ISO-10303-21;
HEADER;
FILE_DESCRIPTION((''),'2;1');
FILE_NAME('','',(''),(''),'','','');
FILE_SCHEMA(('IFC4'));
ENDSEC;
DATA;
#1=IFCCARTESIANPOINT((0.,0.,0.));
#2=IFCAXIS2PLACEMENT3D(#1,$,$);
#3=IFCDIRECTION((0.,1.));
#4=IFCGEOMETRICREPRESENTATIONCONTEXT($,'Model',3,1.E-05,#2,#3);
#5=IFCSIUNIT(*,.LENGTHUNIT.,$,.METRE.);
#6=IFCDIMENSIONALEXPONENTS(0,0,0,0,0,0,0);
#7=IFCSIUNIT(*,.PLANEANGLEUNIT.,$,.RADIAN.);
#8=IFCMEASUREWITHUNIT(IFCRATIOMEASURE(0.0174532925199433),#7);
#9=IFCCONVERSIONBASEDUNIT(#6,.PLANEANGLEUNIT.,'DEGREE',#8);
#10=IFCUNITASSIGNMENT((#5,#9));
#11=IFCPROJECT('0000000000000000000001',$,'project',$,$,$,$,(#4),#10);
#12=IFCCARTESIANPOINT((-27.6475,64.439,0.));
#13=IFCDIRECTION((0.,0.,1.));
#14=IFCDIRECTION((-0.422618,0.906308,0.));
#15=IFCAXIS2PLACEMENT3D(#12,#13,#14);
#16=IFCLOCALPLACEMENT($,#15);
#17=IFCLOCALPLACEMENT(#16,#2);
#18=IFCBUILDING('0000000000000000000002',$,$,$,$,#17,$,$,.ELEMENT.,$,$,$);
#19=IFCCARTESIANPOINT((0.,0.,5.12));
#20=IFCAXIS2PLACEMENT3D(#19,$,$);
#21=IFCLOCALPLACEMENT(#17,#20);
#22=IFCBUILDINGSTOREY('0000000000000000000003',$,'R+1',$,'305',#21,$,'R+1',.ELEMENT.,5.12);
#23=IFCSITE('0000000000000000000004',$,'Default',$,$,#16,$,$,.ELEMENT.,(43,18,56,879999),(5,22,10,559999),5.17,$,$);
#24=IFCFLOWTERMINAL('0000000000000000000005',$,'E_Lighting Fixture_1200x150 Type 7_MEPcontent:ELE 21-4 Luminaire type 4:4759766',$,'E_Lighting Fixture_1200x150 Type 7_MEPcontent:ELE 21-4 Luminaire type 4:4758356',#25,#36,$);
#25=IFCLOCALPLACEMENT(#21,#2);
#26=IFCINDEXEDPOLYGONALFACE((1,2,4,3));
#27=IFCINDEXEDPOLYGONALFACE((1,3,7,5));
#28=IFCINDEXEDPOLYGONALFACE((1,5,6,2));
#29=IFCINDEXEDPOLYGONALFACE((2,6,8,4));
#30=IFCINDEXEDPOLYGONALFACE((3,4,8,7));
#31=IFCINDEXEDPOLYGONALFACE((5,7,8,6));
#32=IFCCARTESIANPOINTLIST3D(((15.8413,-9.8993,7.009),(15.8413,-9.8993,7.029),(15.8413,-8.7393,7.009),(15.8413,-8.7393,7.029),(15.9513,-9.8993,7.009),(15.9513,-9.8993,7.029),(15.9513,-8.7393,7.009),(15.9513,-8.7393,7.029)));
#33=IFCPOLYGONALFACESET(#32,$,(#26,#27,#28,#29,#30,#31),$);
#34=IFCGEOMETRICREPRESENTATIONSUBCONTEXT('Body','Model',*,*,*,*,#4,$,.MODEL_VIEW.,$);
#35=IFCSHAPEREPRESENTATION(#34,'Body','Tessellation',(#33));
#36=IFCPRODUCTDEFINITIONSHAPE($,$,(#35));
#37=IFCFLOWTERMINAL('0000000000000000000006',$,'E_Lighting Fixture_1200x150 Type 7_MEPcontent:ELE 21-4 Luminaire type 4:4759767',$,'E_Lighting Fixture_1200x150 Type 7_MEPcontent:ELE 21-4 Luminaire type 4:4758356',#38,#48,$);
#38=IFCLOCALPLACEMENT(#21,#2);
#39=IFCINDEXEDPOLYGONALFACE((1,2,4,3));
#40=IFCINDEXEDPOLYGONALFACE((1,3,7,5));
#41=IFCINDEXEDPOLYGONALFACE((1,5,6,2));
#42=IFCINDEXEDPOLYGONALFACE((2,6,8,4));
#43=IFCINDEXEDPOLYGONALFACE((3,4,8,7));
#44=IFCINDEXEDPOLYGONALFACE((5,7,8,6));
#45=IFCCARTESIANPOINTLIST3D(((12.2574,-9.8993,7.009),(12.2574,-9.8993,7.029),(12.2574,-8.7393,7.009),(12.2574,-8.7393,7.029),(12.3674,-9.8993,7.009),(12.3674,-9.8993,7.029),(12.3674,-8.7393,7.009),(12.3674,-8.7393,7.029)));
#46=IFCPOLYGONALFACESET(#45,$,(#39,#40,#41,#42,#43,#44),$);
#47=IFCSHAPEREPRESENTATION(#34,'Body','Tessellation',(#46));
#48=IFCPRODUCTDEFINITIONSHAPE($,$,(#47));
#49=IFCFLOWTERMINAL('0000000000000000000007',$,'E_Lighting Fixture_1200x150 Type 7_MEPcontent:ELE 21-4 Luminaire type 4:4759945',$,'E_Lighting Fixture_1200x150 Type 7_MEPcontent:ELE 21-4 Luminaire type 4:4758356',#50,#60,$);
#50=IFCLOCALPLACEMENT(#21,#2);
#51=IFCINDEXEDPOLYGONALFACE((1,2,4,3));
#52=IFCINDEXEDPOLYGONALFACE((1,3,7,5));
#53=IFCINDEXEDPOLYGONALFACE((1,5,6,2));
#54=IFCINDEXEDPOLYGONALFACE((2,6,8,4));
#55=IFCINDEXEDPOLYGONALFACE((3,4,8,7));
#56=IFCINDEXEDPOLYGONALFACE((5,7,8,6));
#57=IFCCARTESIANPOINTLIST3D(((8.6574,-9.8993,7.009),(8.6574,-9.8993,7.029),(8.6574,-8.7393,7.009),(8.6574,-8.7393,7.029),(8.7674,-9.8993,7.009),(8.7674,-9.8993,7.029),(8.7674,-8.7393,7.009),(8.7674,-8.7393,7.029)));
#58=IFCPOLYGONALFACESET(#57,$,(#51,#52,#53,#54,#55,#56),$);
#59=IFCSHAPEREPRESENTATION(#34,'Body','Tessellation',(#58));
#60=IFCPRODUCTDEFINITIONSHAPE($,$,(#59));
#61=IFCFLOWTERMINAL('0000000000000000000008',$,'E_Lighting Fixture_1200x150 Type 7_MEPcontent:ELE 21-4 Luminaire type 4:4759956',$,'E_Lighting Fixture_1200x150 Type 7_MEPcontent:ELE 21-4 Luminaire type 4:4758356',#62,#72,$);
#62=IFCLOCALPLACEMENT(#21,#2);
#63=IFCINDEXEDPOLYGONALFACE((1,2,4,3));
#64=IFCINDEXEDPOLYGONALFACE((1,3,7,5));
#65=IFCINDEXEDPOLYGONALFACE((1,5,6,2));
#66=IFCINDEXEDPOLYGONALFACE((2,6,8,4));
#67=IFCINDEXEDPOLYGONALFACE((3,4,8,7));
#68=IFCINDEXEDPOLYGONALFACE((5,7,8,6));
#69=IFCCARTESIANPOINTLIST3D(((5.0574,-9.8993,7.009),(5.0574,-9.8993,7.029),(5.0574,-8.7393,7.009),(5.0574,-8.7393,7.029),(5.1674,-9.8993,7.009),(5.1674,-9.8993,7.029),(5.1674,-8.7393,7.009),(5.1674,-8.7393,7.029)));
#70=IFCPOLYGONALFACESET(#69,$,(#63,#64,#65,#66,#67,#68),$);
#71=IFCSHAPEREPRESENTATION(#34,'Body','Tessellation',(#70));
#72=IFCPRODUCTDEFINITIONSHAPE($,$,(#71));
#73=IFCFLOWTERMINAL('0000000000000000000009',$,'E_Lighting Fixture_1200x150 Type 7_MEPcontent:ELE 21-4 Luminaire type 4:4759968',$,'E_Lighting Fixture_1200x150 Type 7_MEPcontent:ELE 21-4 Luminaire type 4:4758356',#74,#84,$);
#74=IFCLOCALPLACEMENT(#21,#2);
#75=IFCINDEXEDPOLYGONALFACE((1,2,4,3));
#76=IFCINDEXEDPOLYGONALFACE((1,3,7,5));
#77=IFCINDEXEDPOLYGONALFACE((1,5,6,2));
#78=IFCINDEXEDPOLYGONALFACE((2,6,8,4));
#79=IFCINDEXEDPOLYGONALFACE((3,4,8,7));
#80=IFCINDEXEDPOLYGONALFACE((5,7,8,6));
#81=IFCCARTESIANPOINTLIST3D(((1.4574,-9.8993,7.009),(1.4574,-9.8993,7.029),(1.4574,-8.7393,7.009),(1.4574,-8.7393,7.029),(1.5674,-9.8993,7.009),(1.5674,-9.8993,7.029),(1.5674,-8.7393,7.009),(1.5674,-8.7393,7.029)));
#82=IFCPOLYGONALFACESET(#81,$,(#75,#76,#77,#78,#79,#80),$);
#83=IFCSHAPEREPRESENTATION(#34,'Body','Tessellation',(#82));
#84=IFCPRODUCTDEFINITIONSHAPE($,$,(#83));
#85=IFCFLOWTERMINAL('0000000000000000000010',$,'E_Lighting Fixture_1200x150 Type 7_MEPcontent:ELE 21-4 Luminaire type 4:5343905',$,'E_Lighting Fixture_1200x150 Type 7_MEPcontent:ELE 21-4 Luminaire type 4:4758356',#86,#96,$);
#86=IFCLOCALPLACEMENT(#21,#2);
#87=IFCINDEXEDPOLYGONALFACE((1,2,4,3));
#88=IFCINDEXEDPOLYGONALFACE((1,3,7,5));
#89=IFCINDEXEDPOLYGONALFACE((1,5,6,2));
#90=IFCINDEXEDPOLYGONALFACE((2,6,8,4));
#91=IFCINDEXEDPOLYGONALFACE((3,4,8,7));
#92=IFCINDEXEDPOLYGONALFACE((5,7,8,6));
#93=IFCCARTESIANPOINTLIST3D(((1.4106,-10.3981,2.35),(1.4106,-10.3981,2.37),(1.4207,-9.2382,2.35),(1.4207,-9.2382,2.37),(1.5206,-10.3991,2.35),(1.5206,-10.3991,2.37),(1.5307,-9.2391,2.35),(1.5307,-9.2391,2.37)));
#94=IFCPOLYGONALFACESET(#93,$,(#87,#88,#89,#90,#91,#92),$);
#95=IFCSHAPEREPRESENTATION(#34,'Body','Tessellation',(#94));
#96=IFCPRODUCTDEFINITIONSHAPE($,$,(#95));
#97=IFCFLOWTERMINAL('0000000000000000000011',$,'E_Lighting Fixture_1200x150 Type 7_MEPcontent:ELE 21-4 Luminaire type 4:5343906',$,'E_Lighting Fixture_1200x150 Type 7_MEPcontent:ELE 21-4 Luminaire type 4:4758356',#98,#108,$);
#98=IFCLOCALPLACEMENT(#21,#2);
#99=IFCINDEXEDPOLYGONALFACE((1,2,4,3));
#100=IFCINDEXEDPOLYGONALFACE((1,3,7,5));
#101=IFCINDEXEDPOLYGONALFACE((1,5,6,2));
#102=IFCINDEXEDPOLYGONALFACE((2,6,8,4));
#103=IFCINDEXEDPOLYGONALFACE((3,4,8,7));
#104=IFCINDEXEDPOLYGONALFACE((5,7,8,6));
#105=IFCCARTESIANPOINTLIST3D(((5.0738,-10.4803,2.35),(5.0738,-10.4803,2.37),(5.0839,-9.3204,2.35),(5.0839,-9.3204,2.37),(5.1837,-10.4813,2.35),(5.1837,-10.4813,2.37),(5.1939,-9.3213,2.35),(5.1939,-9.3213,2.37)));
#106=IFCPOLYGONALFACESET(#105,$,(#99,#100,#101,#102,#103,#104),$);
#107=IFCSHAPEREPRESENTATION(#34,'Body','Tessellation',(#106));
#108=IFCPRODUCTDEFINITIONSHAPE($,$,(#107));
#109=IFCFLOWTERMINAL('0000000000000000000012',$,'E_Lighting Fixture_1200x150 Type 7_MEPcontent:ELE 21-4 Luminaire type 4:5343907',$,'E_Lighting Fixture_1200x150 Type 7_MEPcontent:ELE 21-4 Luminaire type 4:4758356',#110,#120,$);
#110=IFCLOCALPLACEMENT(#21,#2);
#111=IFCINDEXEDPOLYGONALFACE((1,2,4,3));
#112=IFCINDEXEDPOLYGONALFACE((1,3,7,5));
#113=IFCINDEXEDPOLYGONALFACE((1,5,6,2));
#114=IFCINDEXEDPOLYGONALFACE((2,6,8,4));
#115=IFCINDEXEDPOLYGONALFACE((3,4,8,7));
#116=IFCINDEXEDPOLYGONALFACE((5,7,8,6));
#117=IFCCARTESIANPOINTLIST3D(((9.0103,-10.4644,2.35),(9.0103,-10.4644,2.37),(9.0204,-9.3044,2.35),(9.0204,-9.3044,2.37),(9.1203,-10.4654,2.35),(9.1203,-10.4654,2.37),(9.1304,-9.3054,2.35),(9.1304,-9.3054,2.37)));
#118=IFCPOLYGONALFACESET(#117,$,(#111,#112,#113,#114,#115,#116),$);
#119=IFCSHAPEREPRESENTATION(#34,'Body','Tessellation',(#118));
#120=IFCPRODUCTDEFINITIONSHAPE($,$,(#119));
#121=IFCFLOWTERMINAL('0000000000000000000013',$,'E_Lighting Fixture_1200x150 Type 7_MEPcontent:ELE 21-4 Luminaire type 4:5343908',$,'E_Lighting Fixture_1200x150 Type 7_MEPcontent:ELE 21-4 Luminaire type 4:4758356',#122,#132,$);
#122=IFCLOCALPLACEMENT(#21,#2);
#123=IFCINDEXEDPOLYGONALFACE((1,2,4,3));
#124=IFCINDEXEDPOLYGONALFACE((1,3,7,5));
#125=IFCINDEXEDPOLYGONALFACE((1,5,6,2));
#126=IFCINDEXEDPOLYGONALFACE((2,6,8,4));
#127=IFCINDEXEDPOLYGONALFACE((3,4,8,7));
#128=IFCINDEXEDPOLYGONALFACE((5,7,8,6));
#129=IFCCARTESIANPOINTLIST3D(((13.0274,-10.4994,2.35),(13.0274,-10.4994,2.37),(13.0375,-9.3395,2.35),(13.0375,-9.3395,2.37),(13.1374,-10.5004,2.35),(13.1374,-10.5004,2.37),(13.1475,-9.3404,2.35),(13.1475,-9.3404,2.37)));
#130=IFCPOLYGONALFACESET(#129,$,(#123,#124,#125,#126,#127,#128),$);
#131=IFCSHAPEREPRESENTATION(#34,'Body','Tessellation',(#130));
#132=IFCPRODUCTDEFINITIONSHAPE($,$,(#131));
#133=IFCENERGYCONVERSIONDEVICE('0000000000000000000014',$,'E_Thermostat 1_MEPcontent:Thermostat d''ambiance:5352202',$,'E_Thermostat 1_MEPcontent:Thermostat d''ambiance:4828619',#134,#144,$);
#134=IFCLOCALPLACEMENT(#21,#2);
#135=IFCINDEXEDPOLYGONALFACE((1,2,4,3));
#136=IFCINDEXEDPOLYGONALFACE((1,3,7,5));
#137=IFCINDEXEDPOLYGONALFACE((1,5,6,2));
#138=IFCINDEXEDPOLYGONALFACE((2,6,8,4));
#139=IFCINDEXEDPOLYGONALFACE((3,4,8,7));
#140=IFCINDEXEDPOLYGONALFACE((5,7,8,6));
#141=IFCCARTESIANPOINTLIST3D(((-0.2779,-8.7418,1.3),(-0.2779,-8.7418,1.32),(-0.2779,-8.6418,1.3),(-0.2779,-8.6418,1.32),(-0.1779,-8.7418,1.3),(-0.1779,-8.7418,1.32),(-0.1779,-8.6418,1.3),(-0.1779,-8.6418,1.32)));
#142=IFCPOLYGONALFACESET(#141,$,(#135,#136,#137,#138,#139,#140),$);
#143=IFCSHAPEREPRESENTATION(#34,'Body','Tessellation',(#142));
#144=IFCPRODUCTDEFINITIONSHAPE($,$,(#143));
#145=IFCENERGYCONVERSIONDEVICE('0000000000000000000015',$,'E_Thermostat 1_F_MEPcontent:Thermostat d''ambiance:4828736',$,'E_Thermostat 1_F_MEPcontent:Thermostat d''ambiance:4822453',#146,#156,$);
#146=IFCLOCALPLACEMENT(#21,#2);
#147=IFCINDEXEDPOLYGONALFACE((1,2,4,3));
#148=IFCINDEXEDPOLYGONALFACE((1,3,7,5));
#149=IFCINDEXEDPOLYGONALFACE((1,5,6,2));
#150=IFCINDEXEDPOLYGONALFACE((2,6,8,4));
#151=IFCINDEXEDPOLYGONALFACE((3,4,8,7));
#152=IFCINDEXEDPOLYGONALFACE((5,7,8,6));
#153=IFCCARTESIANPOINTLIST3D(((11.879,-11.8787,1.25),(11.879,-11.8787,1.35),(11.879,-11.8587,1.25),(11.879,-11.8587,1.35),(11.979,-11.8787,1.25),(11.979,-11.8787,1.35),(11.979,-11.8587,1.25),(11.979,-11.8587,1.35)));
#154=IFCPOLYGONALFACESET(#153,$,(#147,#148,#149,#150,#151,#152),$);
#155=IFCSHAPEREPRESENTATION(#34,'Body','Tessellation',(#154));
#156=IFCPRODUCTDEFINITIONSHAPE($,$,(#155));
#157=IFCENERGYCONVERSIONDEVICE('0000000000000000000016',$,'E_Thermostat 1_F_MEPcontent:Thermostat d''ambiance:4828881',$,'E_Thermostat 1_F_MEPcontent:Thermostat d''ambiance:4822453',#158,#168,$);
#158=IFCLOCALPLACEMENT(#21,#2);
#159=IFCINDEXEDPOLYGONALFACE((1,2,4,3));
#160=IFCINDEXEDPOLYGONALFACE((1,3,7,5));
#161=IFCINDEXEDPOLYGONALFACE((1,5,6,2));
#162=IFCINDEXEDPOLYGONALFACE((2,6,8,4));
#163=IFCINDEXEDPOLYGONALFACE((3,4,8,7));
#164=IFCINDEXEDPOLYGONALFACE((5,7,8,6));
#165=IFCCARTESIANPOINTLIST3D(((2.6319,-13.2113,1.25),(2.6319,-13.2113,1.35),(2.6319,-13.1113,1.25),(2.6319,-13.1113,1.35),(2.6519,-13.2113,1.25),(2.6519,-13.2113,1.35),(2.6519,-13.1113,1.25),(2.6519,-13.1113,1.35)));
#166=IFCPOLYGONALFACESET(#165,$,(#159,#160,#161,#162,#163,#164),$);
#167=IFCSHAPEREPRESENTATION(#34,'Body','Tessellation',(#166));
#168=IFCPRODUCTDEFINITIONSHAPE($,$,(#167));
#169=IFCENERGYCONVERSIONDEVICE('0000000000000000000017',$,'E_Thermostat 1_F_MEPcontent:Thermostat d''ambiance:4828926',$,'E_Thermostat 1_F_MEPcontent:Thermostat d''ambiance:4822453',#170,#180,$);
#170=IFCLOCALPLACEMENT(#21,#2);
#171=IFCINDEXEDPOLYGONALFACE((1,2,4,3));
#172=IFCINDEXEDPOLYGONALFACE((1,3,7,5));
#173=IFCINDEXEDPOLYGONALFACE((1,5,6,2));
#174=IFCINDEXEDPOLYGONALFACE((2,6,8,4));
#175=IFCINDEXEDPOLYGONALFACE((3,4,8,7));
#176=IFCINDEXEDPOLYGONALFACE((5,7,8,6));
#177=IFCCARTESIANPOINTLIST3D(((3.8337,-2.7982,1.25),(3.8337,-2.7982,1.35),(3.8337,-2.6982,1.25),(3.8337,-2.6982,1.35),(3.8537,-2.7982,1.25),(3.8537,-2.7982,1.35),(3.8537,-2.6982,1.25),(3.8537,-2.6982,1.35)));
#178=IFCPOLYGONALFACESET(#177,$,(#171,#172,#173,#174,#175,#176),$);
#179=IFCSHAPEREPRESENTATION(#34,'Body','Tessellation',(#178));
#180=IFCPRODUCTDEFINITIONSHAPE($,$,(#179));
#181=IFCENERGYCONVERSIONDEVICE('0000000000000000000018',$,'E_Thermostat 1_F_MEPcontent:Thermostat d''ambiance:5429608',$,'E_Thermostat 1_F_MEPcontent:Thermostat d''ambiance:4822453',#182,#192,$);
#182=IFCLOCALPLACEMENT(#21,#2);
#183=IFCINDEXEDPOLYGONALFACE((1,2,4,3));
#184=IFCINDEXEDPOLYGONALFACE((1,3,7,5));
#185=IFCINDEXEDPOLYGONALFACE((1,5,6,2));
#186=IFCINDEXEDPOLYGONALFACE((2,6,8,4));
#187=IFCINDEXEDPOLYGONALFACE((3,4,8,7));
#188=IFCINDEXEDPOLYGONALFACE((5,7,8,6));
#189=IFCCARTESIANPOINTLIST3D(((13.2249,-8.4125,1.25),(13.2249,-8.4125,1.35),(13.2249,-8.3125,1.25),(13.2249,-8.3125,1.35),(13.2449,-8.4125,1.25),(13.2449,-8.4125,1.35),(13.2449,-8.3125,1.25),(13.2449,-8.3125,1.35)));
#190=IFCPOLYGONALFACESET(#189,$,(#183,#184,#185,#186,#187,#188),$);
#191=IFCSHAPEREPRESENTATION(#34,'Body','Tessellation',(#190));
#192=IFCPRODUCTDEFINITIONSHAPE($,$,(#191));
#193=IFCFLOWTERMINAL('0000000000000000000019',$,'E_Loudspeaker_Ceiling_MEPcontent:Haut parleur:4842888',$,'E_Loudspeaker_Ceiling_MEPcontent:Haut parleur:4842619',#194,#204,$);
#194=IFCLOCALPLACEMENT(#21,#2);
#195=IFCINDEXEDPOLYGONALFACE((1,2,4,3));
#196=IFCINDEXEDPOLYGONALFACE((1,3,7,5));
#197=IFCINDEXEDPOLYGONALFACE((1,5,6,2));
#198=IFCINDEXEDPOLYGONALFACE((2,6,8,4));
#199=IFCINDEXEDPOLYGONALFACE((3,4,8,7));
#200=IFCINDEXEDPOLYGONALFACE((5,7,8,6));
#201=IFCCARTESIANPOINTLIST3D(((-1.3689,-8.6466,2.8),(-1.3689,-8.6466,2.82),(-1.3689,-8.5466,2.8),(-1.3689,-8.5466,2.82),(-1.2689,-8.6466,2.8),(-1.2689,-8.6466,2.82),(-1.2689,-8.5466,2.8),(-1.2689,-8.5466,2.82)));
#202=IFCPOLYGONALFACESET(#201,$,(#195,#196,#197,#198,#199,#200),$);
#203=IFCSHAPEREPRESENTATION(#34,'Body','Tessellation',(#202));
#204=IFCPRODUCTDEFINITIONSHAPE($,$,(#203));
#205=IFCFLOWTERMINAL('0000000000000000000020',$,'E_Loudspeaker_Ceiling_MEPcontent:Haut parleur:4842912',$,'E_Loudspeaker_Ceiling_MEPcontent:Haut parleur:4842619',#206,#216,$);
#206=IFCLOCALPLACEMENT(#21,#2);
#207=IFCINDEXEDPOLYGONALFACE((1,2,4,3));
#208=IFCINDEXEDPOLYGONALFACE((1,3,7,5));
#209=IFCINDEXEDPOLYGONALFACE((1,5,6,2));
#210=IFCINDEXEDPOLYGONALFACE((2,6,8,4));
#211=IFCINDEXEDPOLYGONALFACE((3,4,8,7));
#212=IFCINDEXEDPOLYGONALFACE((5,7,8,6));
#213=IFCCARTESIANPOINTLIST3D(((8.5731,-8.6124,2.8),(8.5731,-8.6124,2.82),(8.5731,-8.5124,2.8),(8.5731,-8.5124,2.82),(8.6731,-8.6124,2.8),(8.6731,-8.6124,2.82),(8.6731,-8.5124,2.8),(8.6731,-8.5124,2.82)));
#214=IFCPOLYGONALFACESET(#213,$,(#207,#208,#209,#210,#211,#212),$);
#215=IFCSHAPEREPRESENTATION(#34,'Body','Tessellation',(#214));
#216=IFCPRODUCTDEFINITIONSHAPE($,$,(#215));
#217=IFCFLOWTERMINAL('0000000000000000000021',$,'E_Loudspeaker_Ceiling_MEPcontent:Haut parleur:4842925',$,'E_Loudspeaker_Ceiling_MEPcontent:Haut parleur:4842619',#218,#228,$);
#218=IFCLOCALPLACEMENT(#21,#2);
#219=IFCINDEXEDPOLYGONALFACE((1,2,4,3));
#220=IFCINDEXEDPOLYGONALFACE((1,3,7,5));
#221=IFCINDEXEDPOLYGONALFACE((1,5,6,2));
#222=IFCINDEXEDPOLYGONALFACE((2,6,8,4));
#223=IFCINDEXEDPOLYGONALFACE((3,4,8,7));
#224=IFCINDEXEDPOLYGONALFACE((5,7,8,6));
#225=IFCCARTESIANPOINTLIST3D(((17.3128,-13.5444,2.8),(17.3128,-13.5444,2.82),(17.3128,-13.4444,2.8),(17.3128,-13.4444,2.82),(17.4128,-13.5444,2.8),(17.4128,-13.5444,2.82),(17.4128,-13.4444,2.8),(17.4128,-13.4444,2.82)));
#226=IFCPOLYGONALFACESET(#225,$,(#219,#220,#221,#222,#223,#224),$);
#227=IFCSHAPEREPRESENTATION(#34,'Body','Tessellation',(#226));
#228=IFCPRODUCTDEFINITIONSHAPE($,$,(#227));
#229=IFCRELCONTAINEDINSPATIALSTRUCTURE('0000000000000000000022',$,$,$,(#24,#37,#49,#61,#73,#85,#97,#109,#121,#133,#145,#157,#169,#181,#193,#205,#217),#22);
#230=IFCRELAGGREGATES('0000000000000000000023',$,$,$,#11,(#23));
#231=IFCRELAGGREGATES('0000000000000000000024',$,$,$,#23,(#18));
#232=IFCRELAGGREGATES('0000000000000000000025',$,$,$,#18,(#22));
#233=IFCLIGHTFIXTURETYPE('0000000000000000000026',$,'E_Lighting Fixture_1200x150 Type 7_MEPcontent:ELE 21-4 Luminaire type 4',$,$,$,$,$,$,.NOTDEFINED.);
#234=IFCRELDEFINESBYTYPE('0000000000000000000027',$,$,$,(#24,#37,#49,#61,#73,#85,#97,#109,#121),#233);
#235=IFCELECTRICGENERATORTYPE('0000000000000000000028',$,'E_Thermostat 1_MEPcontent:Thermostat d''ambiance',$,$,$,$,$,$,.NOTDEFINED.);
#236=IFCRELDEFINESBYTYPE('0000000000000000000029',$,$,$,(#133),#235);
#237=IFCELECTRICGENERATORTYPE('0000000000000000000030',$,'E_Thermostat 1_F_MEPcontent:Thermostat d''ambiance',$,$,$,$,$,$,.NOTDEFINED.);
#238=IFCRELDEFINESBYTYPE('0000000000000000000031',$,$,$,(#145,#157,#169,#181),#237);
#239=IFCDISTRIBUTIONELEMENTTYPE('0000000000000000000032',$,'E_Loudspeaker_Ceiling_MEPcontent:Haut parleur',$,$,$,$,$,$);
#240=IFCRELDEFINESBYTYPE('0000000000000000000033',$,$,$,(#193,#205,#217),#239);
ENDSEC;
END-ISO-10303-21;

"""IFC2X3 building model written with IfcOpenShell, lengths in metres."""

from ifc_helpers import new_model, entity, si_unit, converted_unit, direction, frame, origin, origin_2d_with_axis, place, context, subcontext, project, spatial, rectangle, extrude, source, transform, mapped, type_object, type_shapes, element, save


model = new_model("IFC2X3")

# Units and contexts
model_context = context("Model", 3, precision=1e-05, world=origin(), true_north=direction((0.0, 1.0)))
body_context = subcontext(model_context, "Body", "Model", "MODEL_VIEW")
ifc_project = project(units=[si_unit("LENGTHUNIT", "METRE"), converted_unit("PLANEANGLEUNIT", "DEGREE", entity("IfcRatioMeasure", 0.0174532925199433), si_unit("PLANEANGLEUNIT", "RADIAN"), dimensions=[0, 0, 0, 0, 0, 0, 0])], contexts=[model_context])

# Site, building, storey
site_placement = place(None, frame((-27.6475, 64.439, 0.0), z_axis=(0.0, 0.0, 1.0), x_axis=(-0.422618, 0.906308, 0.0)))
site = spatial("IfcSite", under=ifc_project, at=site_placement, Name="Default", CompositionType="ELEMENT", RefLatitude=(43, 18, 56, 879999), RefLongitude=(5, 22, 10, 559999), RefElevation=5.17)
building_placement = place(site_placement, origin())
building = spatial("IfcBuilding", under=site, at=building_placement, CompositionType="ELEMENT")
storey_placement = place(building_placement, frame((0.0, 0.0, 5.12)))
storey = spatial("IfcBuildingStorey", under=building, at=storey_placement, Name="R+1", ObjectType="305", LongName="R+1", CompositionType="ELEMENT", Elevation=5.12)

# Flow terminals
light_fixture_type_1 = type_object("IfcLightFixtureType", Name="E_Lighting Fixture_1200x150 Type 7_MEPcontent:ELE 21-4 Luminaire type 4", PredefinedType="NOTDEFINED")
shared_shape_1 = source(origin(), body_context, "Body", "SweptSolid", [
    extrude(rectangle(XDim=0.11, YDim=1.16, at=origin_2d_with_axis()), frame((0.0, 0.0, 0.0), z_axis=(0.0, 0.0, 1.0), x_axis=(0.0, -1.0, 0.0)), (0.0, 0.0, 1.0), 0.02),
])
type_shapes(light_fixture_type_1, [shared_shape_1])
for number, where, z_axis, x_axis, name in (
    (1, (15.8963, -9.3193, 7.009), (0.0, 0.0, 1.0), (0.0, -1.0, 0.0), "E_Lighting Fixture_1200x150 Type 7_MEPcontent:ELE 21-4 Luminaire type 4:4759766"),
    (2, (12.3124, -9.3193, 7.009), (0.0, 0.0, 1.0), (0.0, -1.0, 0.0), "E_Lighting Fixture_1200x150 Type 7_MEPcontent:ELE 21-4 Luminaire type 4:4759767"),
    (3, (8.7124, -9.3193, 7.009), (0.0, 0.0, 1.0), (0.0, -1.0, 0.0), "E_Lighting Fixture_1200x150 Type 7_MEPcontent:ELE 21-4 Luminaire type 4:4759945"),
    (4, (5.1124, -9.3193, 7.009), (0.0, 0.0, 1.0), (0.0, -1.0, 0.0), "E_Lighting Fixture_1200x150 Type 7_MEPcontent:ELE 21-4 Luminaire type 4:4759956"),
    (5, (1.5124, -9.3193, 7.009), (0.0, 0.0, 1.0), (0.0, -1.0, 0.0), "E_Lighting Fixture_1200x150 Type 7_MEPcontent:ELE 21-4 Luminaire type 4:4759968"),
    (6, (1.4706, -9.8186, 2.35), (0.0, 0.0, 1.0), (-0.008718, -0.999962, 0.0), "E_Lighting Fixture_1200x150 Type 7_MEPcontent:ELE 21-4 Luminaire type 4:5343905"),
    (7, (5.1338, -9.9008, 2.35), (0.0, 0.0, 1.0), (-0.008718, -0.999962, 0.0), "E_Lighting Fixture_1200x150 Type 7_MEPcontent:ELE 21-4 Luminaire type 4:5343906"),
    (8, (9.0703, -9.8849, 2.35), (0.0, 0.0, 1.0), (-0.008718, -0.999962, 0.0), "E_Lighting Fixture_1200x150 Type 7_MEPcontent:ELE 21-4 Luminaire type 4:5343907"),
    (9, (13.0875, -9.9199, 2.35), (0.0, 0.0, 1.0), (-0.008718, -0.999962, 0.0), "E_Lighting Fixture_1200x150 Type 7_MEPcontent:ELE 21-4 Luminaire type 4:5343908"),
):
    element("IfcFlowTerminal", number, at=place(storey_placement, frame(where, z_axis=z_axis, x_axis=x_axis)), inside=storey, type_object=light_fixture_type_1, Name=name, ObjectType="E_Lighting Fixture_1200x150 Type 7_MEPcontent:ELE 21-4 Luminaire type 4:4758356", context=body_context, shape_type="MappedRepresentation", body=[
        mapped(shared_shape_1, transform((0.0, 0.0, 0.0), scale=1.0)),
    ])

# Energy conversion devices
electric_generator_type_1 = type_object("IfcElectricGeneratorType", Name="E_Thermostat 1_MEPcontent:Thermostat d'ambiance", PredefinedType="NOTDEFINED")
shared_shape_2 = source(origin(), body_context, "Body", "SweptSolid", [
    extrude(rectangle(XDim=0.1, YDim=0.1, at=origin_2d_with_axis()), frame((0.0, 0.0, 0.0), z_axis=(0.0, 0.0, 1.0), x_axis=(0.0, -1.0, 0.0)), (0.0, 0.0, 1.0), 0.02),
])
type_shapes(electric_generator_type_1, [shared_shape_2])
energy_conversion_device_placement = place(storey_placement, frame((-0.2279, -8.6918, 1.3)))
element("IfcEnergyConversionDevice", 10, at=energy_conversion_device_placement, inside=storey, type_object=electric_generator_type_1, Name="E_Thermostat 1_MEPcontent:Thermostat d'ambiance:5352202", ObjectType="E_Thermostat 1_MEPcontent:Thermostat d'ambiance:4828619", context=body_context, shape_type="MappedRepresentation", body=[
    mapped(shared_shape_2, transform((0.0, 0.0, 0.0), scale=1.0)),
])
electric_generator_type_2 = type_object("IfcElectricGeneratorType", Name="E_Thermostat 1_F_MEPcontent:Thermostat d'ambiance", PredefinedType="NOTDEFINED")
shared_shape_3 = source(origin(), body_context, "Body", "SweptSolid", [
    extrude(rectangle(XDim=0.1, YDim=0.1, at=origin_2d_with_axis()), frame((0.0, 0.0, 0.0), z_axis=(0.0, 0.0, 1.0), x_axis=(0.0, 1.0, 0.0)), (0.0, 0.0, 1.0), 0.02),
])
type_shapes(electric_generator_type_2, [shared_shape_3])
for number, where, z_axis, x_axis, name in (
    (11, (11.929, -11.8587, 1.3), (0.0, -1.0, 0.0), (-1.0, 0.0, 0.0), "E_Thermostat 1_F_MEPcontent:Thermostat d'ambiance:4828736"),
    (12, (2.6519, -13.1613, 1.3), (-1.0, 0.0, 0.0), (0.0, -1.0, 0.0), "E_Thermostat 1_F_MEPcontent:Thermostat d'ambiance:4828881"),
    (13, (3.8537, -2.7482, 1.3), (-1.0, 0.0, 0.0), (0.0, -1.0, 0.0), "E_Thermostat 1_F_MEPcontent:Thermostat d'ambiance:4828926"),
    (14, (13.2449, -8.3625, 1.3), (-1.0, 0.0, 0.0), (0.0, 1.0, 0.0), "E_Thermostat 1_F_MEPcontent:Thermostat d'ambiance:5429608"),
):
    element("IfcEnergyConversionDevice", number, at=place(storey_placement, frame(where, z_axis=z_axis, x_axis=x_axis)), inside=storey, type_object=electric_generator_type_2, Name=name, ObjectType="E_Thermostat 1_F_MEPcontent:Thermostat d'ambiance:4822453", context=body_context, shape_type="MappedRepresentation", body=[
        mapped(shared_shape_3, transform((0.0, 0.0, 0.0), scale=1.0)),
    ])

# Flow terminals
distribution_element_type_1 = type_object("IfcDistributionElementType", Name="E_Loudspeaker_Ceiling_MEPcontent:Haut parleur")
shared_shape_4 = source(origin(), body_context, "Body", "SweptSolid", [
    extrude(rectangle(XDim=0.1, YDim=0.1, at=origin_2d_with_axis()), frame((0.0, 0.0, 0.0), z_axis=(0.0, 0.0, 1.0), x_axis=(0.0, -1.0, 0.0)), (0.0, 0.0, 1.0), 0.02),
])
type_shapes(distribution_element_type_1, [shared_shape_4])
for number, where, name in (
    (15, (-1.3189, -8.5966, 2.8), "E_Loudspeaker_Ceiling_MEPcontent:Haut parleur:4842888"),
    (16, (8.6231, -8.5624, 2.8), "E_Loudspeaker_Ceiling_MEPcontent:Haut parleur:4842912"),
):
    element("IfcFlowTerminal", number, at=place(storey_placement, frame(where)), inside=storey, type_object=distribution_element_type_1, Name=name, ObjectType="E_Loudspeaker_Ceiling_MEPcontent:Haut parleur:4842619", context=body_context, shape_type="MappedRepresentation", body=[
        mapped(shared_shape_4, transform((0.0, 0.0, 0.0), scale=1.0)),
    ])
for number, where, z_axis, x_axis, name in (
    (17, (17.3628, -13.4944, 2.8), (0.0, 0.0, 1.0), (0.0, 1.0, 0.0), "E_Loudspeaker_Ceiling_MEPcontent:Haut parleur:4842925"),
):
    element("IfcFlowTerminal", number, at=place(storey_placement, frame(where, z_axis=z_axis, x_axis=x_axis)), inside=storey, type_object=distribution_element_type_1, Name=name, ObjectType="E_Loudspeaker_Ceiling_MEPcontent:Haut parleur:4842619", context=body_context, shape_type="MappedRepresentation", body=[
        mapped(shared_shape_4, transform((0.0, 0.0, 0.0), scale=1.0)),
    ])

save(model, "model.ifc")
